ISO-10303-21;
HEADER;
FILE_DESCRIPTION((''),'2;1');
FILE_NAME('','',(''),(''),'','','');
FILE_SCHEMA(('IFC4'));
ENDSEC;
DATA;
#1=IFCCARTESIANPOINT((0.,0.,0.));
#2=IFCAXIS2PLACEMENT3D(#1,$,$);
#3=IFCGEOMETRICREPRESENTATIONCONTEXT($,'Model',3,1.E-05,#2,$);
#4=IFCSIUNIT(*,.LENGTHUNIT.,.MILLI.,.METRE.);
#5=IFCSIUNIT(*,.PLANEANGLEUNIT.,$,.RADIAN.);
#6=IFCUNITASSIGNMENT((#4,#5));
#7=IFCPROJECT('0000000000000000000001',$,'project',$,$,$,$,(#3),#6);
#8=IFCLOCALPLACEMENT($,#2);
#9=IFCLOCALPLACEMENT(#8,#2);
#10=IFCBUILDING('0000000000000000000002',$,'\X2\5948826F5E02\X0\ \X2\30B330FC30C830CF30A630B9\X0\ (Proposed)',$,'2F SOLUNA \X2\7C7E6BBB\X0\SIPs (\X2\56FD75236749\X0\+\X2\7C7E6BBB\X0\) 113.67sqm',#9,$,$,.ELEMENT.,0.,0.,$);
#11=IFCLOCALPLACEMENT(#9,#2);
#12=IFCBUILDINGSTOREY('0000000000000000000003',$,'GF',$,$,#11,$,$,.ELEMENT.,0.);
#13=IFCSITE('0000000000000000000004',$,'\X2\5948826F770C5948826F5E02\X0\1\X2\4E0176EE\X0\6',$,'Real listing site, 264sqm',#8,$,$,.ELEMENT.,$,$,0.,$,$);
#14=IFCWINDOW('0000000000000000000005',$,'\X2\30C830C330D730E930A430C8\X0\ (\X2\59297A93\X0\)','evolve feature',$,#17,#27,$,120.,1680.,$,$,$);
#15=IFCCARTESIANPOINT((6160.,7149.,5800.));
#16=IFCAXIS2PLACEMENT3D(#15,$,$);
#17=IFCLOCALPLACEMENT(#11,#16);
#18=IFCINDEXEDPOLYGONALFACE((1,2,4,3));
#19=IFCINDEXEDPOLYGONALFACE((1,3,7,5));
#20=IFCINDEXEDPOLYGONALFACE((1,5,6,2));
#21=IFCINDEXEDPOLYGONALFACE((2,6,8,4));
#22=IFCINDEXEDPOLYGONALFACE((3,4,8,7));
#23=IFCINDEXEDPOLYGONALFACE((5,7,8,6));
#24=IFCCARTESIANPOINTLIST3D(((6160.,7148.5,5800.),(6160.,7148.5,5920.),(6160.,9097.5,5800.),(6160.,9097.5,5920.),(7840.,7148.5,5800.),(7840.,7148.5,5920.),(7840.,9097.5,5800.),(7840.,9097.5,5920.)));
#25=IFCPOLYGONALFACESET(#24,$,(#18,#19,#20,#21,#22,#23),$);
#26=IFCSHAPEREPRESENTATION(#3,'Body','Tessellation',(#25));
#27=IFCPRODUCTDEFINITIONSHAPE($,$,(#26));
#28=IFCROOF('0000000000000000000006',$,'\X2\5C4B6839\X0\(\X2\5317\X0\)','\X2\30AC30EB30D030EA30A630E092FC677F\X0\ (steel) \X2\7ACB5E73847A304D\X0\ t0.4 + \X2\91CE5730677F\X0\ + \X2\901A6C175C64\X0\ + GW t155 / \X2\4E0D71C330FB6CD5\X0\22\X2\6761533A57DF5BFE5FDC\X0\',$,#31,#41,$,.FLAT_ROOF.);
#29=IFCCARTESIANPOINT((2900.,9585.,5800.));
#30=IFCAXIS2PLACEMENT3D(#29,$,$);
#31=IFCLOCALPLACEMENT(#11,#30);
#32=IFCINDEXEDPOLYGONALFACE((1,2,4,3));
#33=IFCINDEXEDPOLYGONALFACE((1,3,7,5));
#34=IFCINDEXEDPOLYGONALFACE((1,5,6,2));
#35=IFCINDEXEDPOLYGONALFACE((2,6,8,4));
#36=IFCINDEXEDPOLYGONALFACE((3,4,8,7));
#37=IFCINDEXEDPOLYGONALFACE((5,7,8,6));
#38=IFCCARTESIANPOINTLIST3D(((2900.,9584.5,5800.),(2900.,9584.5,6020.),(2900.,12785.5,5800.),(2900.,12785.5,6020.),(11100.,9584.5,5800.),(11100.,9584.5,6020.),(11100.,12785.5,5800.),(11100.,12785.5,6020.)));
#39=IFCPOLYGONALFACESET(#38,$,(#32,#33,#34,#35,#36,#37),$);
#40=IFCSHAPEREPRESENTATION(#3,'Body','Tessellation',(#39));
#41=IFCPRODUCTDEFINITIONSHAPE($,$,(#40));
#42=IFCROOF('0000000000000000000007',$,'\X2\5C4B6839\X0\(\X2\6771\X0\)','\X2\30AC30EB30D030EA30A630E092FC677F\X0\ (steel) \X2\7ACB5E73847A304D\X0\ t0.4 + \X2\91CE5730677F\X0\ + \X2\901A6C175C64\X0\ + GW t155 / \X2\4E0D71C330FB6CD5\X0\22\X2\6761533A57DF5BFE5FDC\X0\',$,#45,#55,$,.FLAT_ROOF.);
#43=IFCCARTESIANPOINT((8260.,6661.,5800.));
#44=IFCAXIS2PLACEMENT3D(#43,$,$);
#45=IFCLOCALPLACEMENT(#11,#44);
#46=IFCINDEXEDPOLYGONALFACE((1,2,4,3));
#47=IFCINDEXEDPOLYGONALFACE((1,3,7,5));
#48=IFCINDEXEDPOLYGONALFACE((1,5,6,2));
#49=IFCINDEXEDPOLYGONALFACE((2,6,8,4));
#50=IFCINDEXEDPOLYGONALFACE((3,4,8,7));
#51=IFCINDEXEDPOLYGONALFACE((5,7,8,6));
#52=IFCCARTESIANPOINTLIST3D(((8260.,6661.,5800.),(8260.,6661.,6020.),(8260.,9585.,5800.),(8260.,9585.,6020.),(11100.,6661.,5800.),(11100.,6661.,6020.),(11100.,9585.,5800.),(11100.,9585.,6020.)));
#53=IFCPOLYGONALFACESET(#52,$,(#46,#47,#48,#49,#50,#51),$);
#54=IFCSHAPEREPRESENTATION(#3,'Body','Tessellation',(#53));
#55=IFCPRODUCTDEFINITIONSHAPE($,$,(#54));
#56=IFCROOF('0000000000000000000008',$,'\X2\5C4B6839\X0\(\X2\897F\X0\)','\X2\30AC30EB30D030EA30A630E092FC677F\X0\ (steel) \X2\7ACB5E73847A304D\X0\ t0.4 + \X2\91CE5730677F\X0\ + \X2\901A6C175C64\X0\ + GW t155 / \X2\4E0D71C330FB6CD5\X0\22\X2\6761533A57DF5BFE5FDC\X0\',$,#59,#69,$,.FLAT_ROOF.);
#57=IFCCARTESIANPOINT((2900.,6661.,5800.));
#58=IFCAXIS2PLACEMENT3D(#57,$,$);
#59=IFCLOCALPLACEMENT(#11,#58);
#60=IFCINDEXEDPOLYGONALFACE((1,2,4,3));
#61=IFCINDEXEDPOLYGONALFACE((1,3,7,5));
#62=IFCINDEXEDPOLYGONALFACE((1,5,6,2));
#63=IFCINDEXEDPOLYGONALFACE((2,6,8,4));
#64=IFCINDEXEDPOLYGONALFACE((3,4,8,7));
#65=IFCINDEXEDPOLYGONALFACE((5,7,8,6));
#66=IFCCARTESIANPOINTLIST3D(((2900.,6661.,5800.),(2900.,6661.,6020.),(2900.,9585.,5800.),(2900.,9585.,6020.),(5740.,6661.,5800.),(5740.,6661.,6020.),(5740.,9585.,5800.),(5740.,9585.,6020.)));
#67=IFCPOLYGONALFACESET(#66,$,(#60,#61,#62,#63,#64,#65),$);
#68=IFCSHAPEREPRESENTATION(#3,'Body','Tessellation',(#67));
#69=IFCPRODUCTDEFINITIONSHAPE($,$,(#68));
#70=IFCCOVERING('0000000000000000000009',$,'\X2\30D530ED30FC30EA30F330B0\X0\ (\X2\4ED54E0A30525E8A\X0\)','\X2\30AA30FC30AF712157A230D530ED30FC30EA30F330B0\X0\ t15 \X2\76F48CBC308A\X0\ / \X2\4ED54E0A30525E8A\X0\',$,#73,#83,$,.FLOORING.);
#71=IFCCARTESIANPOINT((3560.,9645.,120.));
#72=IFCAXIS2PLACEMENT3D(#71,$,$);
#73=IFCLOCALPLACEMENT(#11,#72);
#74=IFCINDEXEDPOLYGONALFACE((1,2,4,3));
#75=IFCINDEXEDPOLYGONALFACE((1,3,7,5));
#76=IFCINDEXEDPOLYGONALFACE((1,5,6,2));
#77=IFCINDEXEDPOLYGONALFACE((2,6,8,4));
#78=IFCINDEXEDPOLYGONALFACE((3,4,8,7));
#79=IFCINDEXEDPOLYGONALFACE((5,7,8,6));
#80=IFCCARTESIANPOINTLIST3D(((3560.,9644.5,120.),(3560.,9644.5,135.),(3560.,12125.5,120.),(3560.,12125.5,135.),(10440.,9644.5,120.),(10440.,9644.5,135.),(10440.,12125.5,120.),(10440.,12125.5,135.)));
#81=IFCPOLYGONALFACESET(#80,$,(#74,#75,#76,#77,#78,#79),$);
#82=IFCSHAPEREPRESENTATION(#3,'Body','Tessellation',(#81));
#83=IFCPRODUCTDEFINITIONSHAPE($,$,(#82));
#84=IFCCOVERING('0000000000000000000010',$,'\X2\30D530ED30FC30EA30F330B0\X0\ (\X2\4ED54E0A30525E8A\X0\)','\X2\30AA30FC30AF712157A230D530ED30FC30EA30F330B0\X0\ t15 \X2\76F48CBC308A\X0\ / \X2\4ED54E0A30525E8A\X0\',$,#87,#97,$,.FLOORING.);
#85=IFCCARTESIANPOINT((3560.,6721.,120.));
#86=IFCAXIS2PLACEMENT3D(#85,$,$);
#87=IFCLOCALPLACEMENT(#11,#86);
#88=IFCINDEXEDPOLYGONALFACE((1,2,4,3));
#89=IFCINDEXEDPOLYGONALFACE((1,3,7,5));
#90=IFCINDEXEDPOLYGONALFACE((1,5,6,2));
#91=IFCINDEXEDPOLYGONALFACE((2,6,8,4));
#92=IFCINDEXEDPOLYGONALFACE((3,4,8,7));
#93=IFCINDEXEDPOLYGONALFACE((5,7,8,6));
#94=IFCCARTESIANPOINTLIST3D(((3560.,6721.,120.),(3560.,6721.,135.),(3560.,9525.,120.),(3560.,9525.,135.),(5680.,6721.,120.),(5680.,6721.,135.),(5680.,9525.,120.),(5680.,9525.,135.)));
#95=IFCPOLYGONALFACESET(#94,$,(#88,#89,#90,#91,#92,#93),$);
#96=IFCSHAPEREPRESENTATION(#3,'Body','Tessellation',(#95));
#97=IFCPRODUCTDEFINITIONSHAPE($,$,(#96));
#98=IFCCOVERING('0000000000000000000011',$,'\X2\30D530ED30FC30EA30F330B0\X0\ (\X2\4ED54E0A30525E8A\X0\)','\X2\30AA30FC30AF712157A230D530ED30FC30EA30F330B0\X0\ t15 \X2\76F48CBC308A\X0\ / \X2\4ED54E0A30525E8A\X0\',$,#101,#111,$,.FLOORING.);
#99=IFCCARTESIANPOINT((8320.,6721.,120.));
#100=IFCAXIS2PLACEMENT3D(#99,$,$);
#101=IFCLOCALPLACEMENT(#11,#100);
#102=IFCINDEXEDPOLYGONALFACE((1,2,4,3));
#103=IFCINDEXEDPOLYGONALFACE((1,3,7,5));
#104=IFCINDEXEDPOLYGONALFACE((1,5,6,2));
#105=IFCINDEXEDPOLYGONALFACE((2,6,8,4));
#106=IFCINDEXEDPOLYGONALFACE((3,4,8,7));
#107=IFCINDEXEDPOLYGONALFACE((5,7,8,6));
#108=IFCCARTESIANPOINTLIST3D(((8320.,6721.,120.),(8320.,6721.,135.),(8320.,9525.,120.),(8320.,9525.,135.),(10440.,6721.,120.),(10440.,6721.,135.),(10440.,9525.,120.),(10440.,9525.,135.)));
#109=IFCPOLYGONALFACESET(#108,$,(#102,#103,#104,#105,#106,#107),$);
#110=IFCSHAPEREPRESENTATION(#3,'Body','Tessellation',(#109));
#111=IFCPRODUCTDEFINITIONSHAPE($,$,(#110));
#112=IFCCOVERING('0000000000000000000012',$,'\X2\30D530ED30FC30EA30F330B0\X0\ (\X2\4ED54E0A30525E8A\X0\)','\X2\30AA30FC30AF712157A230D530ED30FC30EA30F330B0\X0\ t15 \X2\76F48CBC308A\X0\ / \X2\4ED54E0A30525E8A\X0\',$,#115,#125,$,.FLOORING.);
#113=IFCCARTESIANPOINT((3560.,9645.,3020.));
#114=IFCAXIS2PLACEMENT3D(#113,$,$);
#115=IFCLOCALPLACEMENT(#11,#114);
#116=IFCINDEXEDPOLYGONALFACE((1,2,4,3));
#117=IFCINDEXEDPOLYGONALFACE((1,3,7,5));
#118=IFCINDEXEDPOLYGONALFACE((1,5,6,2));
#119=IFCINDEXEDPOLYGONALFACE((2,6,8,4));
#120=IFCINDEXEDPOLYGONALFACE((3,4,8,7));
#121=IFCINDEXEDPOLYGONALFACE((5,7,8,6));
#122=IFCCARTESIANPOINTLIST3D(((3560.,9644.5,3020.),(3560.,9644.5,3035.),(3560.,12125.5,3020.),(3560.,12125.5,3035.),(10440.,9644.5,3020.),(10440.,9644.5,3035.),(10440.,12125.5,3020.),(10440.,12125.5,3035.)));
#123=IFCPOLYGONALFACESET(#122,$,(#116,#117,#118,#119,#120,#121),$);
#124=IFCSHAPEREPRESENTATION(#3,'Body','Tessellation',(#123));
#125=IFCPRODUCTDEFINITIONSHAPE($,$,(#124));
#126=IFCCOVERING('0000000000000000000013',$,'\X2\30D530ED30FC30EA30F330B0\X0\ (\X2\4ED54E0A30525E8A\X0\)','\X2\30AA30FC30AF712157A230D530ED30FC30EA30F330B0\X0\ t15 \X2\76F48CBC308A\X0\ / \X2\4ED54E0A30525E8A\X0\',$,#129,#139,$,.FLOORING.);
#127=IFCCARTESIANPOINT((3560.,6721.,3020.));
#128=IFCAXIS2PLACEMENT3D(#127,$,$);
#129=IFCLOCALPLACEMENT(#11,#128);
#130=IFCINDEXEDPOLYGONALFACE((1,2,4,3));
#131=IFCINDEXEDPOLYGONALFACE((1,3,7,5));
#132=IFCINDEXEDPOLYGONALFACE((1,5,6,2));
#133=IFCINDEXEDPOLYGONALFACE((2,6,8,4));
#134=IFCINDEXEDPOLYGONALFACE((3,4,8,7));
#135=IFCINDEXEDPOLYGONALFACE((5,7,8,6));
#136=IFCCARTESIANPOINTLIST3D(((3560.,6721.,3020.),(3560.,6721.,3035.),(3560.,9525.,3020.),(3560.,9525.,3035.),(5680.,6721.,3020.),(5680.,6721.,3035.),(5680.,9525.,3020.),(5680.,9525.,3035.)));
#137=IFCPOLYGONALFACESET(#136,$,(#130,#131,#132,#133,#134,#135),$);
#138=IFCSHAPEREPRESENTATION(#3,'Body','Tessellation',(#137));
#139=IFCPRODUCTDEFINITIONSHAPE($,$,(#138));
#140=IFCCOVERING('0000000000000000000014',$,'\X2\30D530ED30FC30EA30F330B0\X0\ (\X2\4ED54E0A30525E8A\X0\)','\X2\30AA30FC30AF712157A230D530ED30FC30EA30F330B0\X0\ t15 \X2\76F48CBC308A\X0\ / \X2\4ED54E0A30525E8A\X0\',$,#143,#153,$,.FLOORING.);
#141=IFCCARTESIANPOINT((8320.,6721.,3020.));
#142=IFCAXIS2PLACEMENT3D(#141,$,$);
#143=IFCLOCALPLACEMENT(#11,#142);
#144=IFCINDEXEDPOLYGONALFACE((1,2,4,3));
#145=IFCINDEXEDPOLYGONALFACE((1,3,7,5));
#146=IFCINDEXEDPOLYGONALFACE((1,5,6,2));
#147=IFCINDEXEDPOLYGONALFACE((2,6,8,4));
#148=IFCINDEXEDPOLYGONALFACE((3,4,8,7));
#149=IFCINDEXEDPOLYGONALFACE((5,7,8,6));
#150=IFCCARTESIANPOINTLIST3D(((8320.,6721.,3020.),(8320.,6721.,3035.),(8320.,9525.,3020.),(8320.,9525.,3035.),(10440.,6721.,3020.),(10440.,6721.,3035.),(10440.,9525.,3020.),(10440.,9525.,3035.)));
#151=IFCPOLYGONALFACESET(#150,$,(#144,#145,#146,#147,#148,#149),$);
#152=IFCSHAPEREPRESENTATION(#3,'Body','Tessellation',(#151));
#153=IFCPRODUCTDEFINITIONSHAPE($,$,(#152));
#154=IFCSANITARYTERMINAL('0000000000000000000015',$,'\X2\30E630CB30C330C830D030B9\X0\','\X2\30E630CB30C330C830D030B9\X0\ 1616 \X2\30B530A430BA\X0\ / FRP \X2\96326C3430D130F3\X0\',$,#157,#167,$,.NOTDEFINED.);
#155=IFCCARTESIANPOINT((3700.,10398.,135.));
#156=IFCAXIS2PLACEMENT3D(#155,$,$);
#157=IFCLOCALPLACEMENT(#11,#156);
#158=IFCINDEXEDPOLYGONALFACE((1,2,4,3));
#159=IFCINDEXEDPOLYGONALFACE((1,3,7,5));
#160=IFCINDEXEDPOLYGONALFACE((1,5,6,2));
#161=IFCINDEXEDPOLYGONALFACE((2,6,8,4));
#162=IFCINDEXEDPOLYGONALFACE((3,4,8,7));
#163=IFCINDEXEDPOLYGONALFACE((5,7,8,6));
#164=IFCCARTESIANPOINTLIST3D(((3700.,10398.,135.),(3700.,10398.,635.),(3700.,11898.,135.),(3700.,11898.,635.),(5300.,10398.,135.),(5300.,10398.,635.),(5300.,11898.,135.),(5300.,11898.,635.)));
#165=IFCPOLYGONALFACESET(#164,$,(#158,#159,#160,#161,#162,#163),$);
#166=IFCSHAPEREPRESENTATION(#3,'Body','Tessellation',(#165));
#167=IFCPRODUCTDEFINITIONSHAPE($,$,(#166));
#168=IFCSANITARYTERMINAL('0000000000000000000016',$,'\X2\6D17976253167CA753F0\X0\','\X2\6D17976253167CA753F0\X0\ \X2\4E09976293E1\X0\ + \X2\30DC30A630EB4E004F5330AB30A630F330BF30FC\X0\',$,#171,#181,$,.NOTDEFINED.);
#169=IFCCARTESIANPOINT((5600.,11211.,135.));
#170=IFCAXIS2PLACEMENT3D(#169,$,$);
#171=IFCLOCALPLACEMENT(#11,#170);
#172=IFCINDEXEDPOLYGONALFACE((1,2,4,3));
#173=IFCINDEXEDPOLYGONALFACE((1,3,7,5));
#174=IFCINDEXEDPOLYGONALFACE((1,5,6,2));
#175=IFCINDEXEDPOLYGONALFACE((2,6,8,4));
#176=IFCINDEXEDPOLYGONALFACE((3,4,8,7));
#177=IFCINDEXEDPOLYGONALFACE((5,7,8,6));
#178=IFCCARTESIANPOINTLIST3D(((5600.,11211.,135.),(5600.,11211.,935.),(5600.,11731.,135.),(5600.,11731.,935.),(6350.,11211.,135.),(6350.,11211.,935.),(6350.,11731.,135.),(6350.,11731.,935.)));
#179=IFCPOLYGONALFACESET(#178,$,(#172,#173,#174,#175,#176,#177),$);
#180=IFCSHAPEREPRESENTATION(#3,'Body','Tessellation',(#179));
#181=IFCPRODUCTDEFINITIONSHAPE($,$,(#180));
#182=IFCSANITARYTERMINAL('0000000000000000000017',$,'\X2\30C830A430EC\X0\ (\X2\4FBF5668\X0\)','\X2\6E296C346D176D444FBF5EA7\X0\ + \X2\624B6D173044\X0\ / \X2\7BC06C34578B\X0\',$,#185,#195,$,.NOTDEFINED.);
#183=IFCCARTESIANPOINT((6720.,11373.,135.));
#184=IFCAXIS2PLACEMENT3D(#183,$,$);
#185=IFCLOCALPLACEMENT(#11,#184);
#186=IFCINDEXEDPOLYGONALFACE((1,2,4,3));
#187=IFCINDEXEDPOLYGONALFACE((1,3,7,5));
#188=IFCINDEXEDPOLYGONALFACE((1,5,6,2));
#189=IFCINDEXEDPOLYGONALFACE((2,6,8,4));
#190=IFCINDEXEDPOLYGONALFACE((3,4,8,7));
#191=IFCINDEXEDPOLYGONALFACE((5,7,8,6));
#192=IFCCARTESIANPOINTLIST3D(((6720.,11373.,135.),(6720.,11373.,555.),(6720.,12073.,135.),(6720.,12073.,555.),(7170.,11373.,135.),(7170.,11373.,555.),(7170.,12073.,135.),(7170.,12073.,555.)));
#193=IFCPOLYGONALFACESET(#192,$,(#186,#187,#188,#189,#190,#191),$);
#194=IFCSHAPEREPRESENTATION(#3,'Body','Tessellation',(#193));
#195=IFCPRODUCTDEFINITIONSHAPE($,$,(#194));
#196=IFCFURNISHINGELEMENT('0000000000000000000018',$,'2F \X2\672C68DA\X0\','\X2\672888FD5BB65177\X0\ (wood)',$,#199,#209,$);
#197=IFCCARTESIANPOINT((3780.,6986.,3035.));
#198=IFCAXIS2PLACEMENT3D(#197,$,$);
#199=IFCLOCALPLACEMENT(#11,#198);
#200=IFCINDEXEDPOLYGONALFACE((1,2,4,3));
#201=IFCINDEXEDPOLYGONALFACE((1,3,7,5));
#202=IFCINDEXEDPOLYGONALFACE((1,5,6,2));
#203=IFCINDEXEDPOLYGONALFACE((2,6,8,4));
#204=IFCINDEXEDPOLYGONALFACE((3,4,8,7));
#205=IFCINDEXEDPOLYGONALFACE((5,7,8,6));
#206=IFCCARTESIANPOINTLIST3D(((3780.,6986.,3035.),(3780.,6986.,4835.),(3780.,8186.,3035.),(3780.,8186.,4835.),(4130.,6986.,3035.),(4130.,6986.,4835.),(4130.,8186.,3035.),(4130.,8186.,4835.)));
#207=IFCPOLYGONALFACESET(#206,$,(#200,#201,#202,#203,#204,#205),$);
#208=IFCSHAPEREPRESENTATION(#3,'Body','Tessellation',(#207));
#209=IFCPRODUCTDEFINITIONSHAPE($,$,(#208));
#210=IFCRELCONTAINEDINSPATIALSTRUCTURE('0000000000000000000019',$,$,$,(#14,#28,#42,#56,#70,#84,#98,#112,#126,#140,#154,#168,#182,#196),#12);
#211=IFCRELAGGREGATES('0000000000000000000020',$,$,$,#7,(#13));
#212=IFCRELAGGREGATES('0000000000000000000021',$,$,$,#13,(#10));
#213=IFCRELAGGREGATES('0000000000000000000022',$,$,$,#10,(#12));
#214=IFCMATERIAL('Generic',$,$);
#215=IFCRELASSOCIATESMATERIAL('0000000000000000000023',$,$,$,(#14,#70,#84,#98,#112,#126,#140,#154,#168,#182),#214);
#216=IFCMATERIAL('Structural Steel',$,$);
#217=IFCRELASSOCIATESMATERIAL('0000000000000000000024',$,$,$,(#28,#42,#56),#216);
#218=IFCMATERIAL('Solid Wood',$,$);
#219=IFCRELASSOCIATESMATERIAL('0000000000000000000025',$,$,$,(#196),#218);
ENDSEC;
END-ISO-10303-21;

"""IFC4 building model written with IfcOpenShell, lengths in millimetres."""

from ifc_helpers import new_model, si_unit, frame, frame_2d, origin, place, context, project, spatial, rectangle, extrude, material, element, save


model = new_model("IFC4")

# Units and contexts
model_context = context("Model", 3, precision=1e-05, world=origin())
ifc_project = project(units=[si_unit("LENGTHUNIT", "METRE", prefix="MILLI"), si_unit("PLANEANGLEUNIT", "RADIAN")], contexts=[model_context])

# Site, building, storey
site_placement = place(None, origin())
site = spatial("IfcSite", under=ifc_project, at=site_placement, Name="奈良県奈良市1丁目6", ObjectType="Real listing site, 264sqm", CompositionType="ELEMENT", RefElevation=0.0)
building_placement = place(site_placement, origin())
building = spatial("IfcBuilding", under=site, at=building_placement, Name="奈良市 コートハウス (Proposed)", ObjectType="2F SOLUNA 籾殻SIPs (国産杉+籾殻) 113.67sqm", CompositionType="ELEMENT", ElevationOfRefHeight=0.0, ElevationOfTerrain=0.0)
storey_placement = place(building_placement, origin())
storey = spatial("IfcBuildingStorey", under=building, at=storey_placement, Name="GF", CompositionType="ELEMENT", Elevation=0.0)

# Shared definitions
ifc_material_1 = material(Name="Solid Wood")

# Window
ifc_material_2 = material(Name="Generic")
window_1_placement = place(storey_placement, frame((6160.0, 7149.0, 5800.0)))
element("IfcWindow", 1, at=window_1_placement, inside=storey, material=ifc_material_2, Name="トップライト (天窓)", Description="evolve feature", OverallHeight=120.0, OverallWidth=1680.0, context=model_context, shape_type="SweptSolid", body=[
    extrude(rectangle(XDim=1680.0, YDim=1949.0, at=frame_2d((840.0, 974.0))), frame((6160.0, 7149.0, 5800.0)), (0.0, 0.0, 1.0), 120.0),
])

# Roofs
ifc_material_3 = material(Name="Structural Steel")
roof_1_placement = place(storey_placement, frame((2900.0, 9585.0, 5800.0)))
element("IfcRoof", 2, at=roof_1_placement, inside=storey, material=ifc_material_3, Name="屋根(北)", Description="ガルバリウム鋼板 (steel) 立平葺き t0.4 + 野地板 + 通気層 + GW t155 / 不燃・法22条区域対応", PredefinedType="FLAT_ROOF", context=model_context, shape_type="SweptSolid", body=[
    extrude(rectangle(XDim=8200.0, YDim=3201.0, at=frame_2d((4100.0, 1600.0))), frame((2900.0, 9585.0, 5800.0)), (0.0, 0.0, 1.0), 220.0),
])
roof_2_placement = place(storey_placement, frame((8260.0, 6661.0, 5800.0)))
element("IfcRoof", 3, at=roof_2_placement, inside=storey, material=ifc_material_3, Name="屋根(東)", Description="ガルバリウム鋼板 (steel) 立平葺き t0.4 + 野地板 + 通気層 + GW t155 / 不燃・法22条区域対応", PredefinedType="FLAT_ROOF", context=model_context, shape_type="SweptSolid", body=[
    extrude(rectangle(XDim=2840.0, YDim=2924.0, at=frame_2d((1420.0, 1462.0))), frame((8260.0, 6661.0, 5800.0)), (0.0, 0.0, 1.0), 220.0),
])
roof_3_placement = place(storey_placement, frame((2900.0, 6661.0, 5800.0)))
element("IfcRoof", 4, at=roof_3_placement, inside=storey, material=ifc_material_3, Name="屋根(西)", Description="ガルバリウム鋼板 (steel) 立平葺き t0.4 + 野地板 + 通気層 + GW t155 / 不燃・法22条区域対応", PredefinedType="FLAT_ROOF", context=model_context, shape_type="SweptSolid", body=[
    extrude(rectangle(XDim=2840.0, YDim=2924.0, at=frame_2d((1420.0, 1462.0))), frame((2900.0, 6661.0, 5800.0)), (0.0, 0.0, 1.0), 220.0),
])

# Coverings
covering_1_placement = place(storey_placement, frame((3560.0, 9645.0, 120.0)))
element("IfcCovering", 5, at=covering_1_placement, inside=storey, material=ifc_material_2, Name="フローリング (仕上げ床)", Description="オーク無垢フローリング t15 直貼り / 仕上げ床", PredefinedType="FLOORING", context=model_context, shape_type="SweptSolid", body=[
    extrude(rectangle(XDim=6880.0, YDim=2481.0, at=frame_2d((3440.0, 1240.0))), frame((3560.0, 9645.0, 120.0)), (0.0, 0.0, 1.0), 15.0),
])
covering_2_placement = place(storey_placement, frame((3560.0, 6721.0, 120.0)))
element("IfcCovering", 6, at=covering_2_placement, inside=storey, material=ifc_material_2, Name="フローリング (仕上げ床)", Description="オーク無垢フローリング t15 直貼り / 仕上げ床", PredefinedType="FLOORING", context=model_context, shape_type="SweptSolid", body=[
    extrude(rectangle(XDim=2120.0, YDim=2804.0, at=frame_2d((1060.0, 1402.0))), frame((3560.0, 6721.0, 120.0)), (0.0, 0.0, 1.0), 15.0),
])
covering_3_placement = place(storey_placement, frame((8320.0, 6721.0, 120.0)))
element("IfcCovering", 7, at=covering_3_placement, inside=storey, material=ifc_material_2, Name="フローリング (仕上げ床)", Description="オーク無垢フローリング t15 直貼り / 仕上げ床", PredefinedType="FLOORING", context=model_context, shape_type="SweptSolid", body=[
    extrude(rectangle(XDim=2120.0, YDim=2804.0, at=frame_2d((1060.0, 1402.0))), frame((8320.0, 6721.0, 120.0)), (0.0, 0.0, 1.0), 15.0),
])
covering_4_placement = place(storey_placement, frame((3560.0, 9645.0, 3020.0)))
element("IfcCovering", 8, at=covering_4_placement, inside=storey, material=ifc_material_2, Name="フローリング (仕上げ床)", Description="オーク無垢フローリング t15 直貼り / 仕上げ床", PredefinedType="FLOORING", context=model_context, shape_type="SweptSolid", body=[
    extrude(rectangle(XDim=6880.0, YDim=2481.0, at=frame_2d((3440.0, 1240.0))), frame((3560.0, 9645.0, 3020.0)), (0.0, 0.0, 1.0), 15.0),
])
covering_5_placement = place(storey_placement, frame((3560.0, 6721.0, 3020.0)))
element("IfcCovering", 9, at=covering_5_placement, inside=storey, material=ifc_material_2, Name="フローリング (仕上げ床)", Description="オーク無垢フローリング t15 直貼り / 仕上げ床", PredefinedType="FLOORING", context=model_context, shape_type="SweptSolid", body=[
    extrude(rectangle(XDim=2120.0, YDim=2804.0, at=frame_2d((1060.0, 1402.0))), frame((3560.0, 6721.0, 3020.0)), (0.0, 0.0, 1.0), 15.0),
])
covering_6_placement = place(storey_placement, frame((8320.0, 6721.0, 3020.0)))
element("IfcCovering", 10, at=covering_6_placement, inside=storey, material=ifc_material_2, Name="フローリング (仕上げ床)", Description="オーク無垢フローリング t15 直貼り / 仕上げ床", PredefinedType="FLOORING", context=model_context, shape_type="SweptSolid", body=[
    extrude(rectangle(XDim=2120.0, YDim=2804.0, at=frame_2d((1060.0, 1402.0))), frame((8320.0, 6721.0, 3020.0)), (0.0, 0.0, 1.0), 15.0),
])

# Sanitary terminals
sanitary_terminal_1_placement = place(storey_placement, frame((3700.0, 10398.0, 135.0)))
element("IfcSanitaryTerminal", 11, at=sanitary_terminal_1_placement, inside=storey, material=ifc_material_2, Name="ユニットバス", Description="ユニットバス 1616 サイズ / FRP 防水パン", PredefinedType="NOTDEFINED", context=model_context, shape_type="SweptSolid", body=[
    extrude(rectangle(XDim=1600.0, YDim=1500.0, at=frame_2d((800.0, 750.0))), frame((3700.0, 10398.0, 135.0)), (0.0, 0.0, 1.0), 500.0),
])
sanitary_terminal_2_placement = place(storey_placement, frame((5600.0, 11211.0, 135.0)))
element("IfcSanitaryTerminal", 12, at=sanitary_terminal_2_placement, inside=storey, material=ifc_material_2, Name="洗面化粧台", Description="洗面化粧台 三面鏡 + ボウル一体カウンター", PredefinedType="NOTDEFINED", context=model_context, shape_type="SweptSolid", body=[
    extrude(rectangle(XDim=750.0, YDim=520.0, at=frame_2d((375.0, 260.0))), frame((5600.0, 11211.0, 135.0)), (0.0, 0.0, 1.0), 800.0),
])
sanitary_terminal_3_placement = place(storey_placement, frame((6720.0, 11373.0, 135.0)))
element("IfcSanitaryTerminal", 13, at=sanitary_terminal_3_placement, inside=storey, material=ifc_material_2, Name="トイレ (便器)", Description="温水洗浄便座 + 手洗い / 節水型", PredefinedType="NOTDEFINED", context=model_context, shape_type="SweptSolid", body=[
    extrude(rectangle(XDim=450.0, YDim=700.0, at=frame_2d((225.0, 350.0))), frame((6720.0, 11373.0, 135.0)), (0.0, 0.0, 1.0), 420.0),
])

# Furnishing element
furnishing_placement = place(storey_placement, frame((3780.0, 6986.0, 3035.0)))
element("IfcFurnishingElement", 14, at=furnishing_placement, inside=storey, material=ifc_material_1, Name="2F 本棚", Description="木製家具 (wood)", context=model_context, shape_type="SweptSolid", body=[
    extrude(rectangle(XDim=350.0, YDim=1200.0, at=frame_2d((175.0, 600.0))), frame((3780.0, 6986.0, 3035.0)), (0.0, 0.0, 1.0), 1800.0),
])

save(model, "model.ifc")
